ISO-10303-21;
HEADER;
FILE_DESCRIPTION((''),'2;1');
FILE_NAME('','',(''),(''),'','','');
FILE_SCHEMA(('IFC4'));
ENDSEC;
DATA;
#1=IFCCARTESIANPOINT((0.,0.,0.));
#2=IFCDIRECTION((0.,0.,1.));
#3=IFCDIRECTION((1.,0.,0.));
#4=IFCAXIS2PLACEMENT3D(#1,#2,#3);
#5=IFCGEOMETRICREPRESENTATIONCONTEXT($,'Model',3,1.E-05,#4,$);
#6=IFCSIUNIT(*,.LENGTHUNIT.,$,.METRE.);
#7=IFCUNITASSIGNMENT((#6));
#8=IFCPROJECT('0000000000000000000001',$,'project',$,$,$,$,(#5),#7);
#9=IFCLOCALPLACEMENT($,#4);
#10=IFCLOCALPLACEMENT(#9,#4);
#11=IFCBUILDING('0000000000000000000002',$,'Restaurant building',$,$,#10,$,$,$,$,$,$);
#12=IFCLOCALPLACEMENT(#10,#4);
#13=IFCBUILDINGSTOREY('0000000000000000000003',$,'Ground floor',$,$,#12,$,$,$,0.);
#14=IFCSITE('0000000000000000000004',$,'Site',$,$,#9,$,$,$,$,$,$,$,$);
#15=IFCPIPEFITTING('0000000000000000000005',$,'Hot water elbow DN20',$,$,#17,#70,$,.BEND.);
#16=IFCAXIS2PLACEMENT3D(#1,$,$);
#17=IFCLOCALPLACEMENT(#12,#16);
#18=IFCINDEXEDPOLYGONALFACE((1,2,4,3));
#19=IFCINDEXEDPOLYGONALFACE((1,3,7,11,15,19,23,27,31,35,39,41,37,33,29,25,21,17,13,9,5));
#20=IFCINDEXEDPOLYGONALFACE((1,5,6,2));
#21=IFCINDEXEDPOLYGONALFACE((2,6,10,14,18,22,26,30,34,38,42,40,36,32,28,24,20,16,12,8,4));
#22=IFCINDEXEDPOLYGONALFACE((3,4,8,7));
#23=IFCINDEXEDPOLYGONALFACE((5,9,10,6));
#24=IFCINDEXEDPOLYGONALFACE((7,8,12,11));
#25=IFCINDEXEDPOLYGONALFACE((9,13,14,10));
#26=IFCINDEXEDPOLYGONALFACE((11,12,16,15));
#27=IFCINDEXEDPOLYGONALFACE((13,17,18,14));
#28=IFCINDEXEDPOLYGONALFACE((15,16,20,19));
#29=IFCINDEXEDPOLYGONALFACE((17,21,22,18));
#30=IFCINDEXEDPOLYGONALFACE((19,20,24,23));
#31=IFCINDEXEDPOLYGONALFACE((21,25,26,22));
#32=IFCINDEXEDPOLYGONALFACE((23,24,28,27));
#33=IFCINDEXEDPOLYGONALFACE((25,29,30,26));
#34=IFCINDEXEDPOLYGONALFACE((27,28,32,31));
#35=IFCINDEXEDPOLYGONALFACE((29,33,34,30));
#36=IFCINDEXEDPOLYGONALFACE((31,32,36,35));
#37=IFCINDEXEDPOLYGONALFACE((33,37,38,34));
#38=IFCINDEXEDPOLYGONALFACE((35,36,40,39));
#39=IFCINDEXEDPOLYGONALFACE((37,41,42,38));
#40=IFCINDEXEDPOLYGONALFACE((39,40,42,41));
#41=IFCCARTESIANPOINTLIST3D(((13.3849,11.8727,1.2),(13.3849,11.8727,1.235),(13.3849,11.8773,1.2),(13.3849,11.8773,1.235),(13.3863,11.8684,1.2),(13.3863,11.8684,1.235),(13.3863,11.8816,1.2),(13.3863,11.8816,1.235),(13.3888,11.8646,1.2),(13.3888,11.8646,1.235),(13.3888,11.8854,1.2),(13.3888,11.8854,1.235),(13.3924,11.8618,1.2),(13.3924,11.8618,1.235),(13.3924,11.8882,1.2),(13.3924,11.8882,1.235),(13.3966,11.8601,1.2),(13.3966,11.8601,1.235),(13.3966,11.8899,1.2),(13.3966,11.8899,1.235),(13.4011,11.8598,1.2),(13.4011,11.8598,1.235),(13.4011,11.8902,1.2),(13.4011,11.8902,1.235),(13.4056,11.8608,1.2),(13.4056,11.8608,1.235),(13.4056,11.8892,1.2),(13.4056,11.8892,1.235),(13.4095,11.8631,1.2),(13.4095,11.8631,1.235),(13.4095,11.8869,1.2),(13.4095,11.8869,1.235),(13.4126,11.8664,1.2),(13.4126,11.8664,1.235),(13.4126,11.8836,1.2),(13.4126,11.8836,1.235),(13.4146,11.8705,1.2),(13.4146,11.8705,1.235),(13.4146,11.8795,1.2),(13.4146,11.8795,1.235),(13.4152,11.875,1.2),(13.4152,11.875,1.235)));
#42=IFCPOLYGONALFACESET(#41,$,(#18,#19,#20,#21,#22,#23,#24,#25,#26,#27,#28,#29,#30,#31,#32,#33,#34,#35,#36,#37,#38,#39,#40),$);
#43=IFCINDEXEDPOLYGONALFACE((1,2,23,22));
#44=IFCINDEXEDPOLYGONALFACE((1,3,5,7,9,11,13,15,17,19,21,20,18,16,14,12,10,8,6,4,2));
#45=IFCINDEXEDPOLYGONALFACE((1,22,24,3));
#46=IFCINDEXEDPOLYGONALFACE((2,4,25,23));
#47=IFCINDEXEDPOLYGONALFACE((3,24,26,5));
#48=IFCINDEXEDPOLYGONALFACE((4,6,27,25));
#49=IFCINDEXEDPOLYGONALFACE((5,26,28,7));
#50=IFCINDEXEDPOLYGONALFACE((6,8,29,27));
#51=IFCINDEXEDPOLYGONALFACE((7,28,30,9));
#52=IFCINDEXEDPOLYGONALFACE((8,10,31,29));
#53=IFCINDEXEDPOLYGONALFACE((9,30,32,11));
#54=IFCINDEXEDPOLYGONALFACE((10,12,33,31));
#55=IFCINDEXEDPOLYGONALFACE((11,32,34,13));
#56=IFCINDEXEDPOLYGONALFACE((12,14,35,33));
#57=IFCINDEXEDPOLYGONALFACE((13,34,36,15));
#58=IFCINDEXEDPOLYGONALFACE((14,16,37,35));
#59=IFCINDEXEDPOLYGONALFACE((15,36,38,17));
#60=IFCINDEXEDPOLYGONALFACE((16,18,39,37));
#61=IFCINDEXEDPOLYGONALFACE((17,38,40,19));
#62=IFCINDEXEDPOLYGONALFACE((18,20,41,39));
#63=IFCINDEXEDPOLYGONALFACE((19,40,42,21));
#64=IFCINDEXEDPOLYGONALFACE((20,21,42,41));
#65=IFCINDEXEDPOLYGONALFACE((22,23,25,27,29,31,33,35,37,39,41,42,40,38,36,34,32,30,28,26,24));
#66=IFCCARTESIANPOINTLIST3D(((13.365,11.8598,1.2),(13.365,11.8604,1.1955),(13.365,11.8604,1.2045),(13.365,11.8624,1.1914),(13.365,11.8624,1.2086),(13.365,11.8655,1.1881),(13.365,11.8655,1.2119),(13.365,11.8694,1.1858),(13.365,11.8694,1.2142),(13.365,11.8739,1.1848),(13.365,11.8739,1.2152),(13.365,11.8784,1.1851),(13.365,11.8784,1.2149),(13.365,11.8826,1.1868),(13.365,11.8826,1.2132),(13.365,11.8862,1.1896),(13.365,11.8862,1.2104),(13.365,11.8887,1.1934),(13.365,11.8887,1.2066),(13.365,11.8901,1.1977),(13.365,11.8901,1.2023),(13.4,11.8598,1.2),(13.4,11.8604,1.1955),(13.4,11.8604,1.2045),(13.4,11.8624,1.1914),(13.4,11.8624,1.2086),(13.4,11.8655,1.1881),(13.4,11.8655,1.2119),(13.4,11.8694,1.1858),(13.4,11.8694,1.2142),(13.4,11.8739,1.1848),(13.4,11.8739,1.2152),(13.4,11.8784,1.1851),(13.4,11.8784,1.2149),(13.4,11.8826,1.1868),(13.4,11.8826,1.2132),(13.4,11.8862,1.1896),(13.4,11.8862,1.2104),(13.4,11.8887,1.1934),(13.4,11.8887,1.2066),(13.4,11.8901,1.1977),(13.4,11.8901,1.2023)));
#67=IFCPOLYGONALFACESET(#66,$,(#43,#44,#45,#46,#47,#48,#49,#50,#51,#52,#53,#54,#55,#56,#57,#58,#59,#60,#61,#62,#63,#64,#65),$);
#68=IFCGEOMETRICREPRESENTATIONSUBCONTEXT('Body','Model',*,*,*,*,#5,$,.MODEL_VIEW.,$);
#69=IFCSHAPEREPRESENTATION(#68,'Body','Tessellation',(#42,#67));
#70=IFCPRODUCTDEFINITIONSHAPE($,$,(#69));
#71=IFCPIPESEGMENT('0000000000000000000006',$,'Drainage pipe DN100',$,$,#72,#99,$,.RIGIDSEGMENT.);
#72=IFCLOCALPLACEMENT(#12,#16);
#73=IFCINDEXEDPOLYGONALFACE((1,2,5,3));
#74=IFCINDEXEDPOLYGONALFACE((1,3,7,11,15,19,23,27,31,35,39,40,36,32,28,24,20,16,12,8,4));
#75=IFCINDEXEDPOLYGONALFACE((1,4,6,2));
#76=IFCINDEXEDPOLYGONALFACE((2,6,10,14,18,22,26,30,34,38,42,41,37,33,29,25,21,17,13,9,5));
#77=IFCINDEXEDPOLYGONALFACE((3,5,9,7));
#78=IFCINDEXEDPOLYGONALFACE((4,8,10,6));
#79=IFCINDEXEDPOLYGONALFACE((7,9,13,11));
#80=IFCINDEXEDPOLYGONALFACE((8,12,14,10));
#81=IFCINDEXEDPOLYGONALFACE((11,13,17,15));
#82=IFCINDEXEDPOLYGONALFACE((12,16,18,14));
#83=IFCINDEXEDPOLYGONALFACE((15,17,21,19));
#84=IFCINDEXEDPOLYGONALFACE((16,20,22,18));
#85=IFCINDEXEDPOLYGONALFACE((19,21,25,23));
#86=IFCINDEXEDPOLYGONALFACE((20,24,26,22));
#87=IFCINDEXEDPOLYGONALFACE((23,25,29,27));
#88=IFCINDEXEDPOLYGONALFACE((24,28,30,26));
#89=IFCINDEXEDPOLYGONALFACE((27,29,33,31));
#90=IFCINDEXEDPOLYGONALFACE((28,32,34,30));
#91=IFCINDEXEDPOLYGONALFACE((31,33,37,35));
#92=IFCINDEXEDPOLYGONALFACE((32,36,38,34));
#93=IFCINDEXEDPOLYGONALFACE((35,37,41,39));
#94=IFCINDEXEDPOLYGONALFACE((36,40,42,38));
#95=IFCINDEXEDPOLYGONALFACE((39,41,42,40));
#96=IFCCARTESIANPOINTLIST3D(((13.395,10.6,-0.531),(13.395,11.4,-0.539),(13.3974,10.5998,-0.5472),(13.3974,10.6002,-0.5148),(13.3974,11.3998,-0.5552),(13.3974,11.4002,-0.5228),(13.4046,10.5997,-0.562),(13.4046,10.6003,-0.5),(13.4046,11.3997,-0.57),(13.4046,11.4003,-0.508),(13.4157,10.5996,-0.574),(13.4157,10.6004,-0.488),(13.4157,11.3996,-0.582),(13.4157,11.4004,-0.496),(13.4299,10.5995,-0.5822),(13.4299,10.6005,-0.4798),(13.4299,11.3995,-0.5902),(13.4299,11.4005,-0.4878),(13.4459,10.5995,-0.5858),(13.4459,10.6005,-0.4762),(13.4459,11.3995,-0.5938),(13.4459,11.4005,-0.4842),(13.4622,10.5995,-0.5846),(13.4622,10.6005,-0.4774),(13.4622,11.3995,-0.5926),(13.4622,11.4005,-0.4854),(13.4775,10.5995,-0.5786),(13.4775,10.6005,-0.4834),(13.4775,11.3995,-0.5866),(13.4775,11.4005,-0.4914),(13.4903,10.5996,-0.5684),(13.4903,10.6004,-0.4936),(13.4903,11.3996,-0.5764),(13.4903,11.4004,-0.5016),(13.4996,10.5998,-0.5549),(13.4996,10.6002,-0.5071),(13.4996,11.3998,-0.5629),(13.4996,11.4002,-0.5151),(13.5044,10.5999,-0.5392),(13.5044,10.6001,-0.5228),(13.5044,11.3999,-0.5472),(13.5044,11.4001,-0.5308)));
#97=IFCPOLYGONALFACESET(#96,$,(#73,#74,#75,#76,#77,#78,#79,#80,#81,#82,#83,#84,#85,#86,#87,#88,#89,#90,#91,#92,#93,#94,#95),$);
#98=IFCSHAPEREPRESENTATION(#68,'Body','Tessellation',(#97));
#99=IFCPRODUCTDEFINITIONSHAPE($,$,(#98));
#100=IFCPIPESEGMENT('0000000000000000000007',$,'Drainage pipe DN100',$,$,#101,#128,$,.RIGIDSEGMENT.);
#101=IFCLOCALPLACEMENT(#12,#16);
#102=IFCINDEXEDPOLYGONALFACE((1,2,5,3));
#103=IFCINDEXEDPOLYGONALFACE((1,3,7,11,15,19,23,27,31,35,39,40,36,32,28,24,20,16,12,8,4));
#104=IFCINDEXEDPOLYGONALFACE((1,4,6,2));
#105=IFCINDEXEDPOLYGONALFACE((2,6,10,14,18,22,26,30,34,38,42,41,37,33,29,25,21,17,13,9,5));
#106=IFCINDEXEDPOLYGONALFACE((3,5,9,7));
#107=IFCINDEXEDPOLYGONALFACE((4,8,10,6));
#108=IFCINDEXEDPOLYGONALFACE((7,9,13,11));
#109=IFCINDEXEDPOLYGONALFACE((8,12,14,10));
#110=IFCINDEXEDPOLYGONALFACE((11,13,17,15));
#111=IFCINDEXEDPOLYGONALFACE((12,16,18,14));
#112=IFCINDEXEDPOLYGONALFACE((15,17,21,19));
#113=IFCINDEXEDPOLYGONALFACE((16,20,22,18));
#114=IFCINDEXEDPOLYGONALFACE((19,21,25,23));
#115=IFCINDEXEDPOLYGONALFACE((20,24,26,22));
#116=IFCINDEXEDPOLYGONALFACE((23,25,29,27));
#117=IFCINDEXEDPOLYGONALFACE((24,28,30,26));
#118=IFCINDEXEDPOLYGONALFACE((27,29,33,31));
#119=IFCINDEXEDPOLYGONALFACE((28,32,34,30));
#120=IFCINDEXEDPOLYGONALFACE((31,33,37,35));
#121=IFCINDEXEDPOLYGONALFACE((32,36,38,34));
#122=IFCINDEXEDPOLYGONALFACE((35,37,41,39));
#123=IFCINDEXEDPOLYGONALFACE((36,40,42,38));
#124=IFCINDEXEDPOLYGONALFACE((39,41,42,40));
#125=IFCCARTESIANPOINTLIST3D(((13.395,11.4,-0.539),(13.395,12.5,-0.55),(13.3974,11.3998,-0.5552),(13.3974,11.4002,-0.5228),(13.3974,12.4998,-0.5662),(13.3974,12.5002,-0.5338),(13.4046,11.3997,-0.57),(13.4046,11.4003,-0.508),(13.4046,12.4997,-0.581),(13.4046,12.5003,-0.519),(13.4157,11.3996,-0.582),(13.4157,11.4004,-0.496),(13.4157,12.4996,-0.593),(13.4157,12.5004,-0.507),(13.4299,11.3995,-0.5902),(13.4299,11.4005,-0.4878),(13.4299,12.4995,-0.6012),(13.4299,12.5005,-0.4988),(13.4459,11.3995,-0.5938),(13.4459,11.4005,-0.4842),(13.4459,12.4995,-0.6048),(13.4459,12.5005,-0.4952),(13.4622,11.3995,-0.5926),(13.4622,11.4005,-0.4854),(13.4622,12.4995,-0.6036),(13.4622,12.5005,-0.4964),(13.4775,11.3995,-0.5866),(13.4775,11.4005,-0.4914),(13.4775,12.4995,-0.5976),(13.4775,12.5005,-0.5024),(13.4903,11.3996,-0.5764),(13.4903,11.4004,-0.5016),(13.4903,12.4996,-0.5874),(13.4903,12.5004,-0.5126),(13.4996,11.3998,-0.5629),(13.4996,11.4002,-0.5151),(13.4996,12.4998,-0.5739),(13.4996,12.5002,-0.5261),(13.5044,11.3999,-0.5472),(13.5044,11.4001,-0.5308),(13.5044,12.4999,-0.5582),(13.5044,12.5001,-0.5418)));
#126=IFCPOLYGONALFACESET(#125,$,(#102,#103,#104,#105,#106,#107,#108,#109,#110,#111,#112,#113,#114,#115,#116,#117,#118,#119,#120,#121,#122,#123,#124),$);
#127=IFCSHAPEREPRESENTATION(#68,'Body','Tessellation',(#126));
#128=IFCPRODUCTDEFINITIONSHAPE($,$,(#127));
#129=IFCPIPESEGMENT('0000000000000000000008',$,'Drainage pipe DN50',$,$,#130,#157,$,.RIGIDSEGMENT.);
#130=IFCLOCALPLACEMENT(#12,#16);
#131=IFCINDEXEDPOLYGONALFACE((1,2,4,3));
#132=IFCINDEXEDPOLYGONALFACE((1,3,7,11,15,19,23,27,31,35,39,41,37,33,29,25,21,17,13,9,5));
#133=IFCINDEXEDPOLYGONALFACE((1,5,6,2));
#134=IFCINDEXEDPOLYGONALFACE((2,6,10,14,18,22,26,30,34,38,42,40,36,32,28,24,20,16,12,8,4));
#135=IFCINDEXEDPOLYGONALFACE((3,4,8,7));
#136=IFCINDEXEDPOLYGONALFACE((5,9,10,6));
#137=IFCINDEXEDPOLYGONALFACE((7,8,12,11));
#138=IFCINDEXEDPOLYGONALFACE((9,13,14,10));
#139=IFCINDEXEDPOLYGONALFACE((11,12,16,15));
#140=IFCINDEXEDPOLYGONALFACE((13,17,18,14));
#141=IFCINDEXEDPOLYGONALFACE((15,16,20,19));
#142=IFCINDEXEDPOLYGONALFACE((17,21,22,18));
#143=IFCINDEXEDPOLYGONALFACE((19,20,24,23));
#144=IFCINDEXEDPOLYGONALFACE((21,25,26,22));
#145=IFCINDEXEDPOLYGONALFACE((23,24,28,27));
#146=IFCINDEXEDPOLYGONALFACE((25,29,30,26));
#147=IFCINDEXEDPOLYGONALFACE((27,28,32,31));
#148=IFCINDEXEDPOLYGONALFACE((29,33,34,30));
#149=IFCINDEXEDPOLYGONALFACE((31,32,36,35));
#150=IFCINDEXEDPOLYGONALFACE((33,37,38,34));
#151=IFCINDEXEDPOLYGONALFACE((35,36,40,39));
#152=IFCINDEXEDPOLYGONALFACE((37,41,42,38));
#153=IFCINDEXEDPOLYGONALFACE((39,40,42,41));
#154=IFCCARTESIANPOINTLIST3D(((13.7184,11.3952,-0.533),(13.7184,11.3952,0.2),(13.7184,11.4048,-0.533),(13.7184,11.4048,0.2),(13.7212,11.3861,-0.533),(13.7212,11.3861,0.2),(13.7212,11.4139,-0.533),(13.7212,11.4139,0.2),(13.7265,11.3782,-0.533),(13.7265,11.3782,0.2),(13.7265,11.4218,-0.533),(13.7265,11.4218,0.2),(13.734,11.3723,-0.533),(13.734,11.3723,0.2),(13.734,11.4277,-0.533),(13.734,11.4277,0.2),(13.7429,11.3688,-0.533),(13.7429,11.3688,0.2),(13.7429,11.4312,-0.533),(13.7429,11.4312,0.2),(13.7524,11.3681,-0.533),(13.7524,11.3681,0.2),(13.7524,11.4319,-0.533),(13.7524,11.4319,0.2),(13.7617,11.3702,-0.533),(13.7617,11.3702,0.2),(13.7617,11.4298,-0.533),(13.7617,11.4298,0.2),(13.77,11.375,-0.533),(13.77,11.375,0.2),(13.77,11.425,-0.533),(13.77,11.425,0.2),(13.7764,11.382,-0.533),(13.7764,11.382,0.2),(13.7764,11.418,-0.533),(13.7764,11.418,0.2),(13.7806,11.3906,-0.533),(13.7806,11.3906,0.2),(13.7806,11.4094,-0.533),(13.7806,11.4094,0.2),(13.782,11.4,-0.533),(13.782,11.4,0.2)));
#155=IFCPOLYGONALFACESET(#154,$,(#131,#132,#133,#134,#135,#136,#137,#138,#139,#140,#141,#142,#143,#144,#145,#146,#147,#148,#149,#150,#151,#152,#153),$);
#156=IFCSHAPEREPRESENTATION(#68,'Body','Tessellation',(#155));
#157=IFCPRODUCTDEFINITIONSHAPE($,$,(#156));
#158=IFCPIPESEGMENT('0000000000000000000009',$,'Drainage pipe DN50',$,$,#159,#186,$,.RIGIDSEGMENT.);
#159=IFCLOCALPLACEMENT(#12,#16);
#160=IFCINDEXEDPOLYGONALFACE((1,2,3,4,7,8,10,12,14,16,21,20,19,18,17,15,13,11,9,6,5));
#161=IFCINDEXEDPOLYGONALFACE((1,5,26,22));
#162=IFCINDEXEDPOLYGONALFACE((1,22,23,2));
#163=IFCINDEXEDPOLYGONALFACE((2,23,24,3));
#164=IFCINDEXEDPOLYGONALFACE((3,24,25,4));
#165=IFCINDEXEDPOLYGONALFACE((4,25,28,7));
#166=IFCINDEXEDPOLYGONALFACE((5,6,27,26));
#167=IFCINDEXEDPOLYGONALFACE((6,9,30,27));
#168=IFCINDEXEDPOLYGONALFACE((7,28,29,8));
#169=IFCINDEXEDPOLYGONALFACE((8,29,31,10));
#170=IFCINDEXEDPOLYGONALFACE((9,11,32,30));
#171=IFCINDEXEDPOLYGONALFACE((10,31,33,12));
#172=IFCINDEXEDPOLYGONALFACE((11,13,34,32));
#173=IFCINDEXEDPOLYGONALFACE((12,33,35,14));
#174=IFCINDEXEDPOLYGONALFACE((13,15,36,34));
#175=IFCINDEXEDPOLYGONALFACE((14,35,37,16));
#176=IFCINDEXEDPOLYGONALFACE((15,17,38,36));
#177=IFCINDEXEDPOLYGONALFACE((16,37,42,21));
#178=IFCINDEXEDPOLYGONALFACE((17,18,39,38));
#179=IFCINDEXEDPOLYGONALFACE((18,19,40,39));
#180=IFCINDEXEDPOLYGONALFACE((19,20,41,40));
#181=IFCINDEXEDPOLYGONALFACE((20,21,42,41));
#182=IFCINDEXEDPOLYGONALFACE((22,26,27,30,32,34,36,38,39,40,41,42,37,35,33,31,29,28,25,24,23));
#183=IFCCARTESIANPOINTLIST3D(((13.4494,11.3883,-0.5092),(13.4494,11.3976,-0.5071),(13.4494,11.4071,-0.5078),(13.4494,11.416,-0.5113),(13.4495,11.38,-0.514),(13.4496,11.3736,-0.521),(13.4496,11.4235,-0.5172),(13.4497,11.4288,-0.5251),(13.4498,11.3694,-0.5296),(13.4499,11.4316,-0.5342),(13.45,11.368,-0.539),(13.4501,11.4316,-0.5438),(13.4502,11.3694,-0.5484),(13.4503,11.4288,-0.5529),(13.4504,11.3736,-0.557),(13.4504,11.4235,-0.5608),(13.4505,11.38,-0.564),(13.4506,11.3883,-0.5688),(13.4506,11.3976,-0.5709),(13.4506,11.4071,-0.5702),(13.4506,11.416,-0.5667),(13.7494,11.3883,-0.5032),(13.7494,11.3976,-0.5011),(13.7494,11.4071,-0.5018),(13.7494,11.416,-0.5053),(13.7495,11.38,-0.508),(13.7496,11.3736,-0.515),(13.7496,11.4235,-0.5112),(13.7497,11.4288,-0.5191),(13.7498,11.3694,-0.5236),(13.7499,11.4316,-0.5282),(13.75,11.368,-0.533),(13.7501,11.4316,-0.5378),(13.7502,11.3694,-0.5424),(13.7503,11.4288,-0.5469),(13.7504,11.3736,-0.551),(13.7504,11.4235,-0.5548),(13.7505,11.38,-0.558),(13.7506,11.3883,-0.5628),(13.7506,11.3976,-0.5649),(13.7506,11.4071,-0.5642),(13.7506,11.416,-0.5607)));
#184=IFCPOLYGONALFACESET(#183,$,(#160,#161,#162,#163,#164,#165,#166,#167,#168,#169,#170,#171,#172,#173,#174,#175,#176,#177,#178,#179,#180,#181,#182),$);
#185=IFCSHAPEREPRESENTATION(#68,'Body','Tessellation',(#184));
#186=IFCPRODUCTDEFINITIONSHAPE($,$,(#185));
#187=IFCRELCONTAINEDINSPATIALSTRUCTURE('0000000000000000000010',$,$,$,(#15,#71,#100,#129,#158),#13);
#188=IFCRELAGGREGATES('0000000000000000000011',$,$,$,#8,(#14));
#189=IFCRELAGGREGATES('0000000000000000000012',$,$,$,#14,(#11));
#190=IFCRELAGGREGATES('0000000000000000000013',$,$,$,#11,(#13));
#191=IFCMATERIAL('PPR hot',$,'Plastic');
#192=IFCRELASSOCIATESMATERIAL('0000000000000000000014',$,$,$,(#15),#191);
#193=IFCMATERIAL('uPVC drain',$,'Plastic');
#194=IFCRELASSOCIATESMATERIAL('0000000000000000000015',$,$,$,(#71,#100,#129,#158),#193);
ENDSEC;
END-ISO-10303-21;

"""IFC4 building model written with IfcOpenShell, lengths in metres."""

from ifc_helpers import new_model, si_unit, frame, origin, origin_with_axes, origin_2d, place, context, subcontext, project, spatial, circle, extrude, material, element, save


model = new_model("IFC4")

# Units and contexts
model_context = context("Model", 3, precision=1e-05, world=origin_with_axes())
body_context = subcontext(model_context, "Body", "Model", "MODEL_VIEW")
ifc_project = project(units=[si_unit("LENGTHUNIT", "METRE")], contexts=[model_context])

# Site, building, storey
site_placement = place(None, origin_with_axes())
site = spatial("IfcSite", under=ifc_project, at=site_placement, Name="Site")
building_placement = place(site_placement, origin_with_axes())
building = spatial("IfcBuilding", under=site, at=building_placement, Name="Restaurant building")
storey_placement = place(building_placement, origin_with_axes())
storey = spatial("IfcBuildingStorey", under=building, at=storey_placement, Name="Ground floor", Elevation=0.0)

# Shared definitions
ifc_material_1 = material(Name="PPR hot", Category="Plastic")

# Pipe fitting
pipe_fitting_1_placement = place(storey_placement, frame((13.4, 11.875, 1.2)))
element("IfcPipeFitting", 1, at=pipe_fitting_1_placement, inside=storey, material=ifc_material_1, Name="Hot water elbow DN20", PredefinedType="BEND", context=body_context, shape_type="SweptSolid", body=[
    extrude(circle(Radius=0.0152, at=origin_2d()), origin(), (0.0, 0.0, 1.0), 0.035),
    extrude(circle(Radius=0.0152, at=origin_2d()), frame((0.0, 0.0, 0.0), z_axis=(-1.0, 0.0, 0.0), x_axis=(0.0, -1.0, 0.0)), (0.0, 0.0, 1.0), 0.035),
])

# Pipe segments
ifc_material_2 = material(Name="uPVC drain", Category="Plastic")
pipe_segment_1_placement = place(storey_placement, frame((13.45, 10.6, -0.531)))
element("IfcPipeSegment", 2, at=pipe_segment_1_placement, inside=storey, material=ifc_material_2, Name="Drainage pipe DN100", PredefinedType="RIGIDSEGMENT", context=body_context, shape_type="SweptSolid", body=[
    extrude(circle(Radius=0.055, at=origin_2d()), frame((0.0, 0.0, 0.0), z_axis=(0.0, 0.99995, -0.009999), x_axis=(-1.0, 0.0, 0.0)), (0.0, 0.0, 1.0), 0.8),
])
pipe_segment_2_placement = place(storey_placement, frame((13.45, 11.4, -0.539)))
element("IfcPipeSegment", 3, at=pipe_segment_2_placement, inside=storey, material=ifc_material_2, Name="Drainage pipe DN100", PredefinedType="RIGIDSEGMENT", context=body_context, shape_type="SweptSolid", body=[
    extrude(circle(Radius=0.055, at=origin_2d()), frame((0.0, 0.0, 0.0), z_axis=(0.0, 0.99995, -0.009999), x_axis=(-1.0, 0.0, 0.0)), (0.0, 0.0, 1.0), 1.1001),
])
pipe_segment_3_placement = place(storey_placement, frame((13.75, 11.4, 0.2)))
element("IfcPipeSegment", 4, at=pipe_segment_3_placement, inside=storey, material=ifc_material_2, Name="Drainage pipe DN50", PredefinedType="RIGIDSEGMENT", context=body_context, shape_type="SweptSolid", body=[
    extrude(circle(Radius=0.032, at=origin_2d()), frame((0.0, 0.0, 0.0), z_axis=(0.0, 0.0, -1.0), x_axis=(1.0, 0.0, 0.0)), (0.0, 0.0, 1.0), 0.733),
])
pipe_segment_4_placement = place(storey_placement, frame((13.75, 11.4, -0.533)))
element("IfcPipeSegment", 5, at=pipe_segment_4_placement, inside=storey, material=ifc_material_2, Name="Drainage pipe DN50", PredefinedType="RIGIDSEGMENT", context=body_context, shape_type="SweptSolid", body=[
    extrude(circle(Radius=0.032, at=origin_2d()), frame((0.0, 0.0, 0.0), z_axis=(-0.9998, 0.0, -0.019996), x_axis=(0.0, -1.0, 0.0)), (0.0, 0.0, 1.0), 0.3001),
])

save(model, "model.ifc")
